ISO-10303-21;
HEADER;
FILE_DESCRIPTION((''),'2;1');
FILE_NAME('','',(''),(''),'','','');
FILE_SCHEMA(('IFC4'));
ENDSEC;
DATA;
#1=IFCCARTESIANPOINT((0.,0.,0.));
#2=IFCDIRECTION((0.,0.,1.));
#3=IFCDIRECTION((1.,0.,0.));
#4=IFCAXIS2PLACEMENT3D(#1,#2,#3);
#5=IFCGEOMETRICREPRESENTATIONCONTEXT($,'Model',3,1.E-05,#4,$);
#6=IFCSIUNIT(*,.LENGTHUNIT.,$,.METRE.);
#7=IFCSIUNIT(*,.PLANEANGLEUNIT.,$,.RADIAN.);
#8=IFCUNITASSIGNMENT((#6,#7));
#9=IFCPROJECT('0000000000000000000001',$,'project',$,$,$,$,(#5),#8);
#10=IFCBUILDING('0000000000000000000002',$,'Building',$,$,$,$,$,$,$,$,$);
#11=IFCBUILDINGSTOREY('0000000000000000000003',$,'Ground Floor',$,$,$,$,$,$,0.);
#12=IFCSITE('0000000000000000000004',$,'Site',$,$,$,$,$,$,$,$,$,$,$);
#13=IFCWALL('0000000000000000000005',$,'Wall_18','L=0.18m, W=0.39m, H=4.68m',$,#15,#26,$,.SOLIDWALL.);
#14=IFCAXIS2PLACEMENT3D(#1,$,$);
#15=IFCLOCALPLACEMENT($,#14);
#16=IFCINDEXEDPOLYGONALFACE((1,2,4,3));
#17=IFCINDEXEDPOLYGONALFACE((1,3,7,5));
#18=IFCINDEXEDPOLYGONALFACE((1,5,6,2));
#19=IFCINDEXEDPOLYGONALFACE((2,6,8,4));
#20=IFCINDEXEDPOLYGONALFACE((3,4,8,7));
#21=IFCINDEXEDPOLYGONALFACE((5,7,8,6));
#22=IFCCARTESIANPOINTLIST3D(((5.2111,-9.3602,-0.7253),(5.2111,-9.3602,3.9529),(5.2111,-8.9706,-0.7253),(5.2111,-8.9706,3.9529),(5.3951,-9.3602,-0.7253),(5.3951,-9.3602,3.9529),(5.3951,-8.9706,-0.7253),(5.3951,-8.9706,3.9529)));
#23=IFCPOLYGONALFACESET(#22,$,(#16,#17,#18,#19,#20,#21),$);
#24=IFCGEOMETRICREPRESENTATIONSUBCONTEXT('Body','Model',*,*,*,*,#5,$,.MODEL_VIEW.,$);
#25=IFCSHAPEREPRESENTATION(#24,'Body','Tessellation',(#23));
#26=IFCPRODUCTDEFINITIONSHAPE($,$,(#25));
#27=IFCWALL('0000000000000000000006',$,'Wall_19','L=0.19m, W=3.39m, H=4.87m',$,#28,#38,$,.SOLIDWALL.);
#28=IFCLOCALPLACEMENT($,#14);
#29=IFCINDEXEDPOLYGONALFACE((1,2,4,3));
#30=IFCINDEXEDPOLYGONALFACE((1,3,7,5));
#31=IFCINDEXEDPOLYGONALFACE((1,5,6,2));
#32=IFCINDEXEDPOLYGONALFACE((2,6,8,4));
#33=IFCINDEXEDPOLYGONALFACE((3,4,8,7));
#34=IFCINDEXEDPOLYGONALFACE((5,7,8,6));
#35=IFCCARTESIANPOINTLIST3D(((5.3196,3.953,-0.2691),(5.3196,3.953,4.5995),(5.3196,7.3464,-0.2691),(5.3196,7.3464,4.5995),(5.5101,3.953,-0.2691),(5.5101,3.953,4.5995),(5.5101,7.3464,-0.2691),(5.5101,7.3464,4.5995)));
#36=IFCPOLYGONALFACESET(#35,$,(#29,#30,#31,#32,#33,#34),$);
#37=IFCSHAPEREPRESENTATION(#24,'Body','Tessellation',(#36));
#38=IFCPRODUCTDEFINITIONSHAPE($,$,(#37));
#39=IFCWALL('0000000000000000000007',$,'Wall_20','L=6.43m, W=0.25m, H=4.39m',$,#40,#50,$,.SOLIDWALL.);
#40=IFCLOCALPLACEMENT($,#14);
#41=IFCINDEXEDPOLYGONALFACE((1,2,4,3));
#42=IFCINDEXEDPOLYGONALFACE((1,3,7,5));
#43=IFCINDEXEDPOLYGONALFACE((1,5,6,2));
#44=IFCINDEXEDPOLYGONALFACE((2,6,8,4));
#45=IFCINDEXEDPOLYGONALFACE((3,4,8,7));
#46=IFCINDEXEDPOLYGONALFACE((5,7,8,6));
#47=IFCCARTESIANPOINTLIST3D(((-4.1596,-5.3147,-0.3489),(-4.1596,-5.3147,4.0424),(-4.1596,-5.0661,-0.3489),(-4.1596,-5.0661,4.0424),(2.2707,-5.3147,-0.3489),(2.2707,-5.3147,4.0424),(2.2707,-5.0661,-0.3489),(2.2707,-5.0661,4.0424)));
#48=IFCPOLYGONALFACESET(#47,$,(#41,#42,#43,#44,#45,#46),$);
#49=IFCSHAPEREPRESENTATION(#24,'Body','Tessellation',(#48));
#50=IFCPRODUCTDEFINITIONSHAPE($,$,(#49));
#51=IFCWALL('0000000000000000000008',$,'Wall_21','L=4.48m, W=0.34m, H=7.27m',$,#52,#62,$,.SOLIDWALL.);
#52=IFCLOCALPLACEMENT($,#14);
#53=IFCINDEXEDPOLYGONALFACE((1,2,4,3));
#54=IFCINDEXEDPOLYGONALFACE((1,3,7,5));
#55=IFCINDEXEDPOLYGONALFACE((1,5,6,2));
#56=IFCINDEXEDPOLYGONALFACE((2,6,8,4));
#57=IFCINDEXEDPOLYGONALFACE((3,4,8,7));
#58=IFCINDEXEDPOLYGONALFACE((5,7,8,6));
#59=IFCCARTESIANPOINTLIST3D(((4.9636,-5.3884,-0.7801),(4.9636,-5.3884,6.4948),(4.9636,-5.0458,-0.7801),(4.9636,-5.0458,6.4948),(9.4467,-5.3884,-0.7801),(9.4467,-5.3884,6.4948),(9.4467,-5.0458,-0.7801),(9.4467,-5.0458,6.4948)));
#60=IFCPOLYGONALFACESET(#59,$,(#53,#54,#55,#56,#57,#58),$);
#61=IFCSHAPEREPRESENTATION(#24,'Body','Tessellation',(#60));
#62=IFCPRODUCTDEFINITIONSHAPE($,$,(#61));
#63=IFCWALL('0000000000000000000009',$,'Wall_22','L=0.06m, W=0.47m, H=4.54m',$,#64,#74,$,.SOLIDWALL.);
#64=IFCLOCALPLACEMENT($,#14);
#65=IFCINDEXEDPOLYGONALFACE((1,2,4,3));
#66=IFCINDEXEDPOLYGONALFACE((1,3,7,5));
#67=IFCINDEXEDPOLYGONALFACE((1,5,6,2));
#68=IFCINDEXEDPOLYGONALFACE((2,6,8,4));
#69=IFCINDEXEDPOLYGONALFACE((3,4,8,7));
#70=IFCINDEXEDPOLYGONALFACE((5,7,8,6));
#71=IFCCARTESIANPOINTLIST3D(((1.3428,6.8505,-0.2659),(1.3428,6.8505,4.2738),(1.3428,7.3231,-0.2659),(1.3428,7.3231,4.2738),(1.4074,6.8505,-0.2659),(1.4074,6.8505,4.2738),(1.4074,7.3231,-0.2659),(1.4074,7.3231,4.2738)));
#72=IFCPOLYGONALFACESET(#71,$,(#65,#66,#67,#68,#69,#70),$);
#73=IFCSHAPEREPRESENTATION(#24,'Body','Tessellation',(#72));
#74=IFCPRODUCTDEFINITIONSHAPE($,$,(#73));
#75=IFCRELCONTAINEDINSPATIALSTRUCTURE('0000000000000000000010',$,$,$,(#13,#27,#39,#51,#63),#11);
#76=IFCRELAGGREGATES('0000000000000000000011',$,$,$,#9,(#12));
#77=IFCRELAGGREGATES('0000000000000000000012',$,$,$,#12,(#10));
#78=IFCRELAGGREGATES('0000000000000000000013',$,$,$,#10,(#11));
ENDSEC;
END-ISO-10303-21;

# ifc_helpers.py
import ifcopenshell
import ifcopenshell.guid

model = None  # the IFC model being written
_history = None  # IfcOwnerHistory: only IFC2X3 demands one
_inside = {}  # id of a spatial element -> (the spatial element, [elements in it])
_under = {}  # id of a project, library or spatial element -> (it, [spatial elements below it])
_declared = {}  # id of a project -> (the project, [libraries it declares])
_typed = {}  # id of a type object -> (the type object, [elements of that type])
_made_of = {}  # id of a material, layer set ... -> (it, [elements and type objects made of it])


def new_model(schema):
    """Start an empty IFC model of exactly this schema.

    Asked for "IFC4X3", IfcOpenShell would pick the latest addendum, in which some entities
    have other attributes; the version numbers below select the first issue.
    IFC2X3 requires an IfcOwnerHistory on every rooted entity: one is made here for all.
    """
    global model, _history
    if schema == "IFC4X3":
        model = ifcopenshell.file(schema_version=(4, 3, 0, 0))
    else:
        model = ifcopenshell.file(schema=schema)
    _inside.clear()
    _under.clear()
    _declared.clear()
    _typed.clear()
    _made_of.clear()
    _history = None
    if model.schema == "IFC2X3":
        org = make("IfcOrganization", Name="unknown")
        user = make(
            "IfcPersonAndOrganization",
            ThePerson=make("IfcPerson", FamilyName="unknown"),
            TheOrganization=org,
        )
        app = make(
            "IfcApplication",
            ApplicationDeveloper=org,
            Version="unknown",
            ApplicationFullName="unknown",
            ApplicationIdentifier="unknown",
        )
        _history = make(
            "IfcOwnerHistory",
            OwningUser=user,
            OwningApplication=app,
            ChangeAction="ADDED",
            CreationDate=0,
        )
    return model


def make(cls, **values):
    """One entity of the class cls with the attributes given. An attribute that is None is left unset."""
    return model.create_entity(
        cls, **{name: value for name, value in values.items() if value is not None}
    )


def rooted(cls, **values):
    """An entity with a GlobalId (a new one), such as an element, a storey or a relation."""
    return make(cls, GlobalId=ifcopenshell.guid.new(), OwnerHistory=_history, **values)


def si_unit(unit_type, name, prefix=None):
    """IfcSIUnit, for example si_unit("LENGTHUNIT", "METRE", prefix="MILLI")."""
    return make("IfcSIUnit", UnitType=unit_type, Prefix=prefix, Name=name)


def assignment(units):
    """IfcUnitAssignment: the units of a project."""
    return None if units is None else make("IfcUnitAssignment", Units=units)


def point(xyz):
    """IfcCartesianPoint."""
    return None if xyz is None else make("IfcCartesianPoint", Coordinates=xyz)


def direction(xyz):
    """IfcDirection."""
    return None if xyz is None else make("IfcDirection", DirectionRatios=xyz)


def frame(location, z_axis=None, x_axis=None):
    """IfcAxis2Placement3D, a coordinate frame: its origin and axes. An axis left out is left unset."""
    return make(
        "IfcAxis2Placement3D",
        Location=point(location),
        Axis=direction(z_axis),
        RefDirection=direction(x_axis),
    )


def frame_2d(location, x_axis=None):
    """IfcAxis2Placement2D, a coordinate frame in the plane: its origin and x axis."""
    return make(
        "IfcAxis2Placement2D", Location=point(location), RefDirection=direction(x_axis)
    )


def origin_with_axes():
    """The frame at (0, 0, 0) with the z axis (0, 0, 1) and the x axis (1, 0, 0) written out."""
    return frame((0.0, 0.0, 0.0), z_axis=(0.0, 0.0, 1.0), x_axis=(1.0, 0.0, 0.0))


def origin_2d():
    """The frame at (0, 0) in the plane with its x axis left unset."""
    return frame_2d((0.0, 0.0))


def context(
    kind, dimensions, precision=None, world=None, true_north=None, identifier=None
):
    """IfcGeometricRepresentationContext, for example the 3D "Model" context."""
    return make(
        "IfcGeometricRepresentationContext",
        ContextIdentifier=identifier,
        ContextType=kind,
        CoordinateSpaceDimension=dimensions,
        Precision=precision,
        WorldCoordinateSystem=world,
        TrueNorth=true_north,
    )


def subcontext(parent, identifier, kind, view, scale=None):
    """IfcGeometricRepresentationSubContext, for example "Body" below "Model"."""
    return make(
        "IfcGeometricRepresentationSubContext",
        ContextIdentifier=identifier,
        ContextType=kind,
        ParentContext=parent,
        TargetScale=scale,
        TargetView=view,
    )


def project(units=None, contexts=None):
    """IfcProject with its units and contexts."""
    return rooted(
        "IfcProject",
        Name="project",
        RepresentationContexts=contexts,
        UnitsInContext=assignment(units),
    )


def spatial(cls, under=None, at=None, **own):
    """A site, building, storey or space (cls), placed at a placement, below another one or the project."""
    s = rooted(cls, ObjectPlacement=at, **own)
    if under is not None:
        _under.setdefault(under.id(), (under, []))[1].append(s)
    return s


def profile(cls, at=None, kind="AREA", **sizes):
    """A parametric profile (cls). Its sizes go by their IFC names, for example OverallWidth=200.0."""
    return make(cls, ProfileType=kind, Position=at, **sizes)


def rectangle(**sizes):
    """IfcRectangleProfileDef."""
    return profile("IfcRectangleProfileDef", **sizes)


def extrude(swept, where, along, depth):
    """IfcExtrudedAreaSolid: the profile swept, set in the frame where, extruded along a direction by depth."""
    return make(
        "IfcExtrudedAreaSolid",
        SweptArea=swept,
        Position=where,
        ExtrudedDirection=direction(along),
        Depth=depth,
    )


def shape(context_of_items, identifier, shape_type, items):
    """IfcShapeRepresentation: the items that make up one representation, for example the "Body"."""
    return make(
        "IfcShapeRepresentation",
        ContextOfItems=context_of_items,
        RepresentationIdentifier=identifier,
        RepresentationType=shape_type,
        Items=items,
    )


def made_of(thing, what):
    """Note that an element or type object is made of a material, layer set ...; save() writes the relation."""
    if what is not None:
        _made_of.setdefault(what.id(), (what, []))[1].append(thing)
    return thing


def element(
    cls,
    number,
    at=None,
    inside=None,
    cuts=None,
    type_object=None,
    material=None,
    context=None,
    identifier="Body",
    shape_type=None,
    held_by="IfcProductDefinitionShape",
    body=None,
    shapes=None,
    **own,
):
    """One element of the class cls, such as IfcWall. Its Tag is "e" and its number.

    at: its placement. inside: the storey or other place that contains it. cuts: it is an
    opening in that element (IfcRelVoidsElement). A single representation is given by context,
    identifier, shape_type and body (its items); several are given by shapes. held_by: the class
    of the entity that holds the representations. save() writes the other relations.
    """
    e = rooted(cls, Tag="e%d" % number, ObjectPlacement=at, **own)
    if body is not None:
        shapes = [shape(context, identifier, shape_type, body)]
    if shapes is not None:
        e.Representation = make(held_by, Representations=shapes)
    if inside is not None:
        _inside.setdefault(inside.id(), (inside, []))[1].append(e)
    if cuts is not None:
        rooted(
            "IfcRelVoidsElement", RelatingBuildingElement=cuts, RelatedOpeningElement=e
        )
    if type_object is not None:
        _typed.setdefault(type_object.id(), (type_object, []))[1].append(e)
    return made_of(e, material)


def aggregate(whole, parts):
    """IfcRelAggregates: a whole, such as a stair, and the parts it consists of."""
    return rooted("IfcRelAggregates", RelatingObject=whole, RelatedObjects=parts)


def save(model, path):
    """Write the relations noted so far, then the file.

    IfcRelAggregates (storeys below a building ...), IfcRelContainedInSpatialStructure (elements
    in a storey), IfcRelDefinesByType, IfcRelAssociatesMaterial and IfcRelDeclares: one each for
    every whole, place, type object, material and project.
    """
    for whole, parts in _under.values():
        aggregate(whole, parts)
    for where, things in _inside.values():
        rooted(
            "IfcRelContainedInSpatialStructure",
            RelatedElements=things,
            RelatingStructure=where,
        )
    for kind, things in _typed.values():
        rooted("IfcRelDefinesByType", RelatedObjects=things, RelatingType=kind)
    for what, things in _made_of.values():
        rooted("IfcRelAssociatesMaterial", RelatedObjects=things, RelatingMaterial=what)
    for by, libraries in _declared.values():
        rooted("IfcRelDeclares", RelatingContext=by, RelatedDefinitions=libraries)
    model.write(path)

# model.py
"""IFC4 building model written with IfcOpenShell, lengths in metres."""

from ifc_helpers import new_model, si_unit, frame, origin_with_axes, origin_2d, context, subcontext, project, spatial, rectangle, extrude, element, save


model = new_model("IFC4")

# Units and contexts
model_context = context("Model", 3, precision=1e-05, world=origin_with_axes())
body_context = subcontext(model_context, "Body", "Model", "MODEL_VIEW")
ifc_project = project(units=[si_unit("LENGTHUNIT", "METRE"), si_unit("PLANEANGLEUNIT", "RADIAN")], contexts=[model_context])

# Site, building, storey
site = spatial("IfcSite", under=ifc_project, Name="Site")
building = spatial("IfcBuilding", under=site, Name="Building")
storey = spatial("IfcBuildingStorey", under=building, Name="Ground Floor", Elevation=0.0)

# Walls
element("IfcWall", 1, inside=storey, Name="Wall_18", Description="L=0.18m, W=0.39m, H=4.68m", PredefinedType="SOLIDWALL", context=body_context, shape_type="SweptSolid", body=[
    extrude(rectangle(XDim=0.184, YDim=0.3896, at=origin_2d()), frame((5.3031, -9.1654, -0.7253), z_axis=(0.0, 0.0, 1.0), x_axis=(1.0, 0.0, 0.0)), (0.0, 0.0, 1.0), 4.6782),
])
element("IfcWall", 2, inside=storey, Name="Wall_19", Description="L=0.19m, W=3.39m, H=4.87m", PredefinedType="SOLIDWALL", context=body_context, shape_type="SweptSolid", body=[
    extrude(rectangle(XDim=0.1906, YDim=3.3933, at=origin_2d()), frame((5.4148, 5.6497, -0.2691), z_axis=(0.0, 0.0, 1.0), x_axis=(1.0, 0.0, 0.0)), (0.0, 0.0, 1.0), 4.8686),
])
element("IfcWall", 3, inside=storey, Name="Wall_20", Description="L=6.43m, W=0.25m, H=4.39m", PredefinedType="SOLIDWALL", context=body_context, shape_type="SweptSolid", body=[
    extrude(rectangle(XDim=6.4303, YDim=0.2487, at=origin_2d()), frame((-0.9445, -5.1904, -0.3489), z_axis=(0.0, 0.0, 1.0), x_axis=(1.0, 0.0, 0.0)), (0.0, 0.0, 1.0), 4.3913),
])
element("IfcWall", 4, inside=storey, Name="Wall_21", Description="L=4.48m, W=0.34m, H=7.27m", PredefinedType="SOLIDWALL", context=body_context, shape_type="SweptSolid", body=[
    extrude(rectangle(XDim=4.4831, YDim=0.3426, at=origin_2d()), frame((7.2052, -5.2171, -0.7801), z_axis=(0.0, 0.0, 1.0), x_axis=(1.0, 0.0, 0.0)), (0.0, 0.0, 1.0), 7.2749),
])
element("IfcWall", 5, inside=storey, Name="Wall_22", Description="L=0.06m, W=0.47m, H=4.54m", PredefinedType="SOLIDWALL", context=body_context, shape_type="SweptSolid", body=[
    extrude(rectangle(XDim=0.0646, YDim=0.4726, at=origin_2d()), frame((1.3751, 7.0868, -0.2659), z_axis=(0.0, 0.0, 1.0), x_axis=(1.0, 0.0, 0.0)), (0.0, 0.0, 1.0), 4.5397),
])

save(model, "model.ifc")
